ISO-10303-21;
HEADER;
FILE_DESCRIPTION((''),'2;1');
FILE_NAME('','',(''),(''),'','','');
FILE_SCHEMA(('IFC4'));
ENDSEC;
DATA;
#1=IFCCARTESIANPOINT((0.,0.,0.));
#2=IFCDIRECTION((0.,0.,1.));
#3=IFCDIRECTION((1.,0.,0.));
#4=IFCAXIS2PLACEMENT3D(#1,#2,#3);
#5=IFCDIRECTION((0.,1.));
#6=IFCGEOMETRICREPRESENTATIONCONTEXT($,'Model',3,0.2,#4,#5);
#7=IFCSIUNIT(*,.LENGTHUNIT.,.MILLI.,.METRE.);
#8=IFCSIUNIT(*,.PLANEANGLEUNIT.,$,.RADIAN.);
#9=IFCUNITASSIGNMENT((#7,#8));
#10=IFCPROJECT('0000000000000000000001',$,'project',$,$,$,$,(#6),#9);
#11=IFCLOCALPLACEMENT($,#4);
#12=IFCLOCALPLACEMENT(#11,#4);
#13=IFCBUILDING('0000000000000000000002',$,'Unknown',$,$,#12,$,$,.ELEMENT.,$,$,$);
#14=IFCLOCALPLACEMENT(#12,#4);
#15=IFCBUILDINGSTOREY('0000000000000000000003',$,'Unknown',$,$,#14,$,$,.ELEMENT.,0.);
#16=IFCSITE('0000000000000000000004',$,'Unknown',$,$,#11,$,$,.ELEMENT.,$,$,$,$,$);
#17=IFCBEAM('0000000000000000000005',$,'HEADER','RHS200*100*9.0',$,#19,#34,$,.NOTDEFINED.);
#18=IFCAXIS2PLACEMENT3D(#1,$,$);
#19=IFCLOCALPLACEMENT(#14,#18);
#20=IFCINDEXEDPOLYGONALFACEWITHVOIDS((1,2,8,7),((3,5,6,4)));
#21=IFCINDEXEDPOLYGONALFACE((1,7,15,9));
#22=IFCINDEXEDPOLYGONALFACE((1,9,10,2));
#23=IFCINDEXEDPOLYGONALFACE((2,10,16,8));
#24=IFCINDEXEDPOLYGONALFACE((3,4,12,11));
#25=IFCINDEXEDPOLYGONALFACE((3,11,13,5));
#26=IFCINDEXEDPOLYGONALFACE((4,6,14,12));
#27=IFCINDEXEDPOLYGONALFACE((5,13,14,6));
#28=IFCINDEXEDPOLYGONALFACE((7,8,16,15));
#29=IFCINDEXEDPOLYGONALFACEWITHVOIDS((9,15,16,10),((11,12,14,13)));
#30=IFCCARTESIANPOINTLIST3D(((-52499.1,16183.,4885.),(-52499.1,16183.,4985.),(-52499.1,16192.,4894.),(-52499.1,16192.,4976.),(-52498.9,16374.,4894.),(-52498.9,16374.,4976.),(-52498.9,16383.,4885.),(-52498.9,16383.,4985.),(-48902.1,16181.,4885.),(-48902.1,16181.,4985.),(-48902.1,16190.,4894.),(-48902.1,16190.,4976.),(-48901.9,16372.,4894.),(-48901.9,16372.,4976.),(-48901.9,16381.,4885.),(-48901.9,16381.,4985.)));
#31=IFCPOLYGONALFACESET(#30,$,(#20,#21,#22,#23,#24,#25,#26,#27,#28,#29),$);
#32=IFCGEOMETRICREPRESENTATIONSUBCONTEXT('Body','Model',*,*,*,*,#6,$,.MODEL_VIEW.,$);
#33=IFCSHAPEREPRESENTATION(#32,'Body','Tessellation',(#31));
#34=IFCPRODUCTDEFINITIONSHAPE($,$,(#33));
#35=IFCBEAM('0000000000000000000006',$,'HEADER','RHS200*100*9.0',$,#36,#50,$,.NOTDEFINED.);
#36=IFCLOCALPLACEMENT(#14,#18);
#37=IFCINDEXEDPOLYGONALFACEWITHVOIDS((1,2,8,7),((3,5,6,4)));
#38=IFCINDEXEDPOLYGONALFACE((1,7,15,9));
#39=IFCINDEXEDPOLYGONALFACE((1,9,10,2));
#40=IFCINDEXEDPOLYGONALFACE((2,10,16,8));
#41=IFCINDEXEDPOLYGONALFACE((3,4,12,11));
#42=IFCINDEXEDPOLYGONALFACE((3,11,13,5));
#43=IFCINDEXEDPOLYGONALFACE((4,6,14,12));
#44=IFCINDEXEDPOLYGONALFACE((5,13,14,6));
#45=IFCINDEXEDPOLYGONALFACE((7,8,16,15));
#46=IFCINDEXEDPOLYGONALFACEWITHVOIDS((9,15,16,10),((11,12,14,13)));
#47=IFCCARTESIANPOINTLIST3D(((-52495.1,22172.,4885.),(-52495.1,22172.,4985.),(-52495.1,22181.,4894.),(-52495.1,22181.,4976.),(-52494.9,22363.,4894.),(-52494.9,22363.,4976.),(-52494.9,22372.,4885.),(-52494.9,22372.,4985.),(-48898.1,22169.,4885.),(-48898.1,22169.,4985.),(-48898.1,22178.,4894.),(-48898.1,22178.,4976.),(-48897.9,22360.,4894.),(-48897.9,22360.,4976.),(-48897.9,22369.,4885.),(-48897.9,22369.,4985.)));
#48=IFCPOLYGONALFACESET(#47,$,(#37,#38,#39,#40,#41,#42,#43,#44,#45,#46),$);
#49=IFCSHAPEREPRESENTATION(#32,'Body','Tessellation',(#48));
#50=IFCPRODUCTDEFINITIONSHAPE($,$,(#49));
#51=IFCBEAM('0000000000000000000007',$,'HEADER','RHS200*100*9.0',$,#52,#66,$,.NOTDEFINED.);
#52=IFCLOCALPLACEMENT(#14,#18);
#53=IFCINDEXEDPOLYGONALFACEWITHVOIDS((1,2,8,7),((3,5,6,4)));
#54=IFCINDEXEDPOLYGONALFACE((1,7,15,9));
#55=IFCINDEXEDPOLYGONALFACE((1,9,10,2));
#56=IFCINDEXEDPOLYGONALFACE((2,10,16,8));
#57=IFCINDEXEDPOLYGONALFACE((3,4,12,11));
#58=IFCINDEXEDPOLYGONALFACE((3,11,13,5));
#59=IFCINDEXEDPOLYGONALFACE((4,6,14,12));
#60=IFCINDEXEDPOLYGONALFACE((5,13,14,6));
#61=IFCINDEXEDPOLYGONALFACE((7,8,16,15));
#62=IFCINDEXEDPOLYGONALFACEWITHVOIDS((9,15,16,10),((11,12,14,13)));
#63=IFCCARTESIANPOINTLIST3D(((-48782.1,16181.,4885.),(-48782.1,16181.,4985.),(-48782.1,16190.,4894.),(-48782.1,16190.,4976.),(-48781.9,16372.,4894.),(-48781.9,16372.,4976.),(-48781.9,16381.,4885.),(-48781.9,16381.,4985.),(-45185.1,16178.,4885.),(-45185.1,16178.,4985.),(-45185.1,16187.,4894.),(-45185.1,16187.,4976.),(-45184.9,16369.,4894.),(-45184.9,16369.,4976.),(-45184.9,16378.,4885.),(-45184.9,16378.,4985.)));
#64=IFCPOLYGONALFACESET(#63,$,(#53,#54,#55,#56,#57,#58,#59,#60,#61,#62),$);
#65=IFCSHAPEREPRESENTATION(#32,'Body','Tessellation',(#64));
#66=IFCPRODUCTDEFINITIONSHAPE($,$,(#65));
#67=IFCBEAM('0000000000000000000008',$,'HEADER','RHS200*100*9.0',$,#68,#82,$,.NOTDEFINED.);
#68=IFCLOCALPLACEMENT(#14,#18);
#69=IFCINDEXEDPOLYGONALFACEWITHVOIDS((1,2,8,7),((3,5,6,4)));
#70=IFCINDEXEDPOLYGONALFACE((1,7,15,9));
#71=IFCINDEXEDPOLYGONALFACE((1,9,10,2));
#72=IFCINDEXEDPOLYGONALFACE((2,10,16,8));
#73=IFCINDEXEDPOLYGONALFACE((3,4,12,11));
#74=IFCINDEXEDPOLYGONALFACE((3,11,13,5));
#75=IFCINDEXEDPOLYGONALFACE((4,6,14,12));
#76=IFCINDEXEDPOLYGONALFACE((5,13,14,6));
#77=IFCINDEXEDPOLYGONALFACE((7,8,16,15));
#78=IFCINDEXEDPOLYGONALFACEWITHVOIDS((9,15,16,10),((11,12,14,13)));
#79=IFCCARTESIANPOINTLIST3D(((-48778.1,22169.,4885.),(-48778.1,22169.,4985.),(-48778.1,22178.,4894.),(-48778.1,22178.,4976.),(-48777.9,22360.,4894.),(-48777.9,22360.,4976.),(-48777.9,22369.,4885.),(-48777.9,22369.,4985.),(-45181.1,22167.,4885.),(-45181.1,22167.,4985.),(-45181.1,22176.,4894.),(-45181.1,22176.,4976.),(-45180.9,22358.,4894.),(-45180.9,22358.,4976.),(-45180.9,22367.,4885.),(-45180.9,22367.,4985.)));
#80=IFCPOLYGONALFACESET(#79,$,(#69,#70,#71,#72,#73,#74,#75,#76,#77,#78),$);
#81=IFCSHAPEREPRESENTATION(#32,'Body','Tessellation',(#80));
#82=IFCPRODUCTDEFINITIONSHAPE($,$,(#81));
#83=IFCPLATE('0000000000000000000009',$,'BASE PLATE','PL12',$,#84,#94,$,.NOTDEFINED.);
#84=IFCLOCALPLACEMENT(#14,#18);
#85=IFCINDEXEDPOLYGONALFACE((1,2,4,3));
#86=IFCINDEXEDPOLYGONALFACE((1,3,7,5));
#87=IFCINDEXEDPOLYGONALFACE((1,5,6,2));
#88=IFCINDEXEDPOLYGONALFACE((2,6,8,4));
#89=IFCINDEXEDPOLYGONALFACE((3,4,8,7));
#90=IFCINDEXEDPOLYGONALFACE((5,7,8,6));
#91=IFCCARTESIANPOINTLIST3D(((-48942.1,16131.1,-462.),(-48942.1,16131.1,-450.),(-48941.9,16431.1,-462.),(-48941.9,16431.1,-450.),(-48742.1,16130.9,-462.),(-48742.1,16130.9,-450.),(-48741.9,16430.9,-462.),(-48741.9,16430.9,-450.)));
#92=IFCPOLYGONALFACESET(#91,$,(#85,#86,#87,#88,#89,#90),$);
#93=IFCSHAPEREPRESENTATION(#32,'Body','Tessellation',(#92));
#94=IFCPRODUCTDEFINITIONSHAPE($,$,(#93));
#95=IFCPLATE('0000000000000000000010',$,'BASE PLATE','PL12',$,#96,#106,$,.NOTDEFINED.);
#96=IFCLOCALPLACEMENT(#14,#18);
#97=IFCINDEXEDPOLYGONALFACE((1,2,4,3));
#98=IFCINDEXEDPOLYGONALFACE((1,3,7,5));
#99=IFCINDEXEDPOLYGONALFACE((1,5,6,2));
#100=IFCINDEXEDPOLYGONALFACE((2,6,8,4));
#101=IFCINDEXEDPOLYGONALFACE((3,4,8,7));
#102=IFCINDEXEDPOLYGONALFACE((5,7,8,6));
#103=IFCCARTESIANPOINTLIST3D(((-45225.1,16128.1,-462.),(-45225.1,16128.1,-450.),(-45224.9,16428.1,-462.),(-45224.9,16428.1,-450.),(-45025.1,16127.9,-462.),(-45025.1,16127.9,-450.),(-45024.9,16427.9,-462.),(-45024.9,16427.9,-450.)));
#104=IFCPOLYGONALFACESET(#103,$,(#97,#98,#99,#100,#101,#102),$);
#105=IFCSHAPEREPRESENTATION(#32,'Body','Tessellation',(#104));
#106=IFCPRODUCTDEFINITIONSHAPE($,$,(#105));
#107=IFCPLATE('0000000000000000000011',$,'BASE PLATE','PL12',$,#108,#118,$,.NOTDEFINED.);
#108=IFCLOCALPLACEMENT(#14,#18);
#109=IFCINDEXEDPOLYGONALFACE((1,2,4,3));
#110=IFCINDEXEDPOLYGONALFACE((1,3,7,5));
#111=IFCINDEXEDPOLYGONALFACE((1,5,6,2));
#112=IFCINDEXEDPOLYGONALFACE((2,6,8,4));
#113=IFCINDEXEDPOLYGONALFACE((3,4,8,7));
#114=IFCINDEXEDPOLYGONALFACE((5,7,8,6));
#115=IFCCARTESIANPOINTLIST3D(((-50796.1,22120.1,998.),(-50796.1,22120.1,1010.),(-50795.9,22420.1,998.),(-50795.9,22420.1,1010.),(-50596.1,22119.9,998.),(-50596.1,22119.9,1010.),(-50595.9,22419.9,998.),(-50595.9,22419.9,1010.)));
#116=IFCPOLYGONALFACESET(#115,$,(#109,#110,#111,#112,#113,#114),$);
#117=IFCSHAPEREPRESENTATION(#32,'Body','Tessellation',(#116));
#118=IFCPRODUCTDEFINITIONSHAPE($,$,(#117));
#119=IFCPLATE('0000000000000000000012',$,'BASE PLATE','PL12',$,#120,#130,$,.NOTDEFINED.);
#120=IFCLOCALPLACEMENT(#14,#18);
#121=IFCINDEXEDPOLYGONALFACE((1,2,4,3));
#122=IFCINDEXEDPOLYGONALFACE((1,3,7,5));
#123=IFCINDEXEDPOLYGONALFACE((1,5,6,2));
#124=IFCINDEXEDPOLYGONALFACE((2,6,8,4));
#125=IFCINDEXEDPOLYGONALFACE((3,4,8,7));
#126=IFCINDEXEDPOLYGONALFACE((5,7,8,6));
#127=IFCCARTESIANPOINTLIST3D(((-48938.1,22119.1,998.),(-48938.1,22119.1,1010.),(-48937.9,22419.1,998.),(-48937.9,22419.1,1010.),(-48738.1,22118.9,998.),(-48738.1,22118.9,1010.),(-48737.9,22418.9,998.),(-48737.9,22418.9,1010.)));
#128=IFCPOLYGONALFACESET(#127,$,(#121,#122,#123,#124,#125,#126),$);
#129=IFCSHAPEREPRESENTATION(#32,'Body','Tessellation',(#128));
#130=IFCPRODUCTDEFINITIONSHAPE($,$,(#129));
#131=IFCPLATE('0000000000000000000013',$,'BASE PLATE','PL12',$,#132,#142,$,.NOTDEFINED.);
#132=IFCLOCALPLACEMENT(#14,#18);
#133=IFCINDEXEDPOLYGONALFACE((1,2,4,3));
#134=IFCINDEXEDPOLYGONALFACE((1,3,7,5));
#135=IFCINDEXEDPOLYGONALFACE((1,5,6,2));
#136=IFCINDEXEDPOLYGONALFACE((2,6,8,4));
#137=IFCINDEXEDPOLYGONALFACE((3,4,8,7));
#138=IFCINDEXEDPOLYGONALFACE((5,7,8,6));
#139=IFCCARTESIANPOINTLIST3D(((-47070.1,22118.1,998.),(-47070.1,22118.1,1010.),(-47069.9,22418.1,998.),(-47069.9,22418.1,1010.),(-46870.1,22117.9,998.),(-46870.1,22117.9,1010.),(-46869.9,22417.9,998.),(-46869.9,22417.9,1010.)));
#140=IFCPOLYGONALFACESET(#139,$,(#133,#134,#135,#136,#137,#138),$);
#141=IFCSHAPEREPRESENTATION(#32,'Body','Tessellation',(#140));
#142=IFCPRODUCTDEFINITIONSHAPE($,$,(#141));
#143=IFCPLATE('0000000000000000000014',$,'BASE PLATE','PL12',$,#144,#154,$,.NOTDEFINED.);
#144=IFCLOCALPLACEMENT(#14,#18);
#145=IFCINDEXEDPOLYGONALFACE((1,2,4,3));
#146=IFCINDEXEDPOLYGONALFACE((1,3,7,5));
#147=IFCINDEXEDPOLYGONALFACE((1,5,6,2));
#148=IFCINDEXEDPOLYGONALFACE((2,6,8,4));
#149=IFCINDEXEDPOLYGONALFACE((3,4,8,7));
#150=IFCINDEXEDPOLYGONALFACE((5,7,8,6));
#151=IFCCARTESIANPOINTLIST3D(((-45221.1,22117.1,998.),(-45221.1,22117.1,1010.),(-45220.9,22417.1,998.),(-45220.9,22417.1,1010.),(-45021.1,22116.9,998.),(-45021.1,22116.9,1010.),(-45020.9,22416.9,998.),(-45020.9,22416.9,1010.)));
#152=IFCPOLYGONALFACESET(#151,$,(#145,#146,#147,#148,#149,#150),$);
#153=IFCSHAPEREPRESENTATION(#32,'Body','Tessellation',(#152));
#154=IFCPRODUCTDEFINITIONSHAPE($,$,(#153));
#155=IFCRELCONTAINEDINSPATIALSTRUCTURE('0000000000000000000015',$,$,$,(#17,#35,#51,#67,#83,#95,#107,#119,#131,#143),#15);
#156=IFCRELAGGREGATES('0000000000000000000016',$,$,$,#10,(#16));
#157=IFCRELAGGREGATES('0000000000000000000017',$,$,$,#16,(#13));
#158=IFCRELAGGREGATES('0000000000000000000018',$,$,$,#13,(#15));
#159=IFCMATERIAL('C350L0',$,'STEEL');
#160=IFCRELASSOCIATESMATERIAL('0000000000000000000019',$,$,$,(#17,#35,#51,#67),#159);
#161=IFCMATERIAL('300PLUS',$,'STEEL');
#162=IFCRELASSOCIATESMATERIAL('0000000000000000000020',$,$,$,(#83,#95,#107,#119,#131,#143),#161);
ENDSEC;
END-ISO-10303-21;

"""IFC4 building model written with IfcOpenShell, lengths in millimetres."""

from ifc_helpers import new_model, si_unit, direction, frame, origin_with_axes, place, context, subcontext, project, spatial, line, indexed_curve, outline, extrude, material, element, save


model = new_model("IFC4")

# Units and contexts
model_context = context("Model", 3, precision=0.2, world=origin_with_axes(), true_north=direction((0.0, 1.0)))
body_context = subcontext(model_context, "Body", "Model", "MODEL_VIEW")
ifc_project = project(units=[si_unit("LENGTHUNIT", "METRE", prefix="MILLI"), si_unit("PLANEANGLEUNIT", "RADIAN")], contexts=[model_context])

# Site, building, storey
site_placement = place(None, origin_with_axes())
site = spatial("IfcSite", under=ifc_project, at=site_placement, Name="Unknown", CompositionType="ELEMENT")
building_placement = place(site_placement, origin_with_axes())
building = spatial("IfcBuilding", under=site, at=building_placement, Name="Unknown", CompositionType="ELEMENT")
storey_placement = place(building_placement, origin_with_axes())
storey = spatial("IfcBuildingStorey", under=building, at=storey_placement, Name="Unknown", CompositionType="ELEMENT", Elevation=0.0)

# Shared definitions
ifc_material_1 = material(Name="C350L0", Category="STEEL")

# Beams
beam_1_placement = place(storey_placement, frame((-48902.0, 16281.0, 4935.0), z_axis=(0.0, 0.0, 1.0), x_axis=(-1.0, 0.000556, 0.0)))
element("IfcBeam", 1, at=beam_1_placement, inside=storey, material=ifc_material_1, Name="HEADER", Description="RHS200*100*9.0", PredefinedType="NOTDEFINED", context=body_context, shape_type="SolidModel", body=[
    extrude(outline(indexed_curve([(-50.0, -100.0), (50.0, -100.0), (50.0, 100.0), (-50.0, 100.0)], segments=[line(1, 2, 3, 4, 1)]), holes=[indexed_curve([(-41.0, -91.0), (-41.0, 91.0), (41.0, 91.0), (41.0, -91.0)], segments=[line(1, 2, 3, 4, 1)])]), frame((0.0, 0.0, 0.0), z_axis=(-1.0, 0.0, 0.0), x_axis=(0.0, 0.0, 1.0)), (0.0, 0.0, -1.0), 3597.0),
])
for number, where, z_axis, x_axis, name in (
    (2, (-48898.0, 22269.0, 4935.0), (0.0, 0.0, 1.0), (-1.0, 0.000834, 0.0), "HEADER"),
    (3, (-45185.0, 16278.0, 4935.0), (0.0, 0.0, 1.0), (-1.0, 0.000834, 0.0), "HEADER"),
):
    element("IfcBeam", number, at=place(storey_placement, frame(where, z_axis=z_axis, x_axis=x_axis)), inside=storey, material=ifc_material_1, Name=name, Description="RHS200*100*9.0", PredefinedType="NOTDEFINED", context=body_context, shape_type="SolidModel", body=[
        extrude(outline(indexed_curve([(-50.0, -100.0), (50.0, -100.0), (50.0, 100.0), (-50.0, 100.0)], segments=[line(1, 2, 3, 4, 1)]), holes=[indexed_curve([(-41.0, -91.0), (-41.0, 91.0), (41.0, 91.0), (41.0, -91.0)], segments=[line(1, 2, 3, 4, 1)])]), frame((0.0, 0.0, 0.0), z_axis=(-1.0, 0.0, 0.0), x_axis=(0.0, 0.0, 1.0)), (0.0, 0.0, -1.0), 3597.0),
    ])
beam_2_placement = place(storey_placement, frame((-45181.0, 22267.0, 4935.0), z_axis=(0.0, 0.0, 1.0), x_axis=(-1.0, 0.000556, 0.0)))
element("IfcBeam", 4, at=beam_2_placement, inside=storey, material=ifc_material_1, Name="HEADER", Description="RHS200*100*9.0", PredefinedType="NOTDEFINED", context=body_context, shape_type="SolidModel", body=[
    extrude(outline(indexed_curve([(-50.0, -100.0), (50.0, -100.0), (50.0, 100.0), (-50.0, 100.0)], segments=[line(1, 2, 3, 4, 1)]), holes=[indexed_curve([(-41.0, -91.0), (-41.0, 91.0), (41.0, 91.0), (41.0, -91.0)], segments=[line(1, 2, 3, 4, 1)])]), frame((0.0, 0.0, 0.0), z_axis=(-1.0, 0.0, 0.0), x_axis=(0.0, 0.0, 1.0)), (0.0, 0.0, -1.0), 3597.0),
])

# Plates
ifc_material_2 = material(Name="300PLUS", Category="STEEL")
for number, where, z_axis, x_axis, name in (
    (5, (-48941.9, 16431.1, -456.0), (0.0, 0.0, 1.0), (-0.000667, -1.0, 0.0), "BASE PLATE"),
    (6, (-45224.9, 16428.1, -456.0), (0.0, 0.0, 1.0), (-0.000667, -1.0, 0.0), "BASE PLATE"),
    (7, (-50795.9, 22420.1, 1004.0), (0.0, 0.0, 1.0), (-0.000667, -1.0, 0.0), "BASE PLATE"),
    (8, (-48937.9, 22419.1, 1004.0), (0.0, 0.0, 1.0), (-0.000667, -1.0, 0.0), "BASE PLATE"),
    (9, (-47069.9, 22418.1, 1004.0), (0.0, 0.0, 1.0), (-0.000667, -1.0, 0.0), "BASE PLATE"),
    (10, (-45220.9, 22417.1, 1004.0), (0.0, 0.0, 1.0), (-0.000667, -1.0, 0.0), "BASE PLATE"),
):
    element("IfcPlate", number, at=place(storey_placement, frame(where, z_axis=z_axis, x_axis=x_axis)), inside=storey, material=ifc_material_2, Name=name, Description="PL12", PredefinedType="NOTDEFINED", context=body_context, shape_type="SolidModel", body=[
        extrude(outline(indexed_curve([(0.0, 0.0), (300.0, 0.0), (300.1, 200.0), (0.1, 200.0)], segments=[line(1, 2, 3, 4, 1)])), frame((0.0, 0.0, 6.0), z_axis=(0.0, 0.0, 1.0), x_axis=(1.0, 0.0, 0.0)), (0.0, 0.0, -1.0), 12.0),
    ])

save(model, "model.ifc")
